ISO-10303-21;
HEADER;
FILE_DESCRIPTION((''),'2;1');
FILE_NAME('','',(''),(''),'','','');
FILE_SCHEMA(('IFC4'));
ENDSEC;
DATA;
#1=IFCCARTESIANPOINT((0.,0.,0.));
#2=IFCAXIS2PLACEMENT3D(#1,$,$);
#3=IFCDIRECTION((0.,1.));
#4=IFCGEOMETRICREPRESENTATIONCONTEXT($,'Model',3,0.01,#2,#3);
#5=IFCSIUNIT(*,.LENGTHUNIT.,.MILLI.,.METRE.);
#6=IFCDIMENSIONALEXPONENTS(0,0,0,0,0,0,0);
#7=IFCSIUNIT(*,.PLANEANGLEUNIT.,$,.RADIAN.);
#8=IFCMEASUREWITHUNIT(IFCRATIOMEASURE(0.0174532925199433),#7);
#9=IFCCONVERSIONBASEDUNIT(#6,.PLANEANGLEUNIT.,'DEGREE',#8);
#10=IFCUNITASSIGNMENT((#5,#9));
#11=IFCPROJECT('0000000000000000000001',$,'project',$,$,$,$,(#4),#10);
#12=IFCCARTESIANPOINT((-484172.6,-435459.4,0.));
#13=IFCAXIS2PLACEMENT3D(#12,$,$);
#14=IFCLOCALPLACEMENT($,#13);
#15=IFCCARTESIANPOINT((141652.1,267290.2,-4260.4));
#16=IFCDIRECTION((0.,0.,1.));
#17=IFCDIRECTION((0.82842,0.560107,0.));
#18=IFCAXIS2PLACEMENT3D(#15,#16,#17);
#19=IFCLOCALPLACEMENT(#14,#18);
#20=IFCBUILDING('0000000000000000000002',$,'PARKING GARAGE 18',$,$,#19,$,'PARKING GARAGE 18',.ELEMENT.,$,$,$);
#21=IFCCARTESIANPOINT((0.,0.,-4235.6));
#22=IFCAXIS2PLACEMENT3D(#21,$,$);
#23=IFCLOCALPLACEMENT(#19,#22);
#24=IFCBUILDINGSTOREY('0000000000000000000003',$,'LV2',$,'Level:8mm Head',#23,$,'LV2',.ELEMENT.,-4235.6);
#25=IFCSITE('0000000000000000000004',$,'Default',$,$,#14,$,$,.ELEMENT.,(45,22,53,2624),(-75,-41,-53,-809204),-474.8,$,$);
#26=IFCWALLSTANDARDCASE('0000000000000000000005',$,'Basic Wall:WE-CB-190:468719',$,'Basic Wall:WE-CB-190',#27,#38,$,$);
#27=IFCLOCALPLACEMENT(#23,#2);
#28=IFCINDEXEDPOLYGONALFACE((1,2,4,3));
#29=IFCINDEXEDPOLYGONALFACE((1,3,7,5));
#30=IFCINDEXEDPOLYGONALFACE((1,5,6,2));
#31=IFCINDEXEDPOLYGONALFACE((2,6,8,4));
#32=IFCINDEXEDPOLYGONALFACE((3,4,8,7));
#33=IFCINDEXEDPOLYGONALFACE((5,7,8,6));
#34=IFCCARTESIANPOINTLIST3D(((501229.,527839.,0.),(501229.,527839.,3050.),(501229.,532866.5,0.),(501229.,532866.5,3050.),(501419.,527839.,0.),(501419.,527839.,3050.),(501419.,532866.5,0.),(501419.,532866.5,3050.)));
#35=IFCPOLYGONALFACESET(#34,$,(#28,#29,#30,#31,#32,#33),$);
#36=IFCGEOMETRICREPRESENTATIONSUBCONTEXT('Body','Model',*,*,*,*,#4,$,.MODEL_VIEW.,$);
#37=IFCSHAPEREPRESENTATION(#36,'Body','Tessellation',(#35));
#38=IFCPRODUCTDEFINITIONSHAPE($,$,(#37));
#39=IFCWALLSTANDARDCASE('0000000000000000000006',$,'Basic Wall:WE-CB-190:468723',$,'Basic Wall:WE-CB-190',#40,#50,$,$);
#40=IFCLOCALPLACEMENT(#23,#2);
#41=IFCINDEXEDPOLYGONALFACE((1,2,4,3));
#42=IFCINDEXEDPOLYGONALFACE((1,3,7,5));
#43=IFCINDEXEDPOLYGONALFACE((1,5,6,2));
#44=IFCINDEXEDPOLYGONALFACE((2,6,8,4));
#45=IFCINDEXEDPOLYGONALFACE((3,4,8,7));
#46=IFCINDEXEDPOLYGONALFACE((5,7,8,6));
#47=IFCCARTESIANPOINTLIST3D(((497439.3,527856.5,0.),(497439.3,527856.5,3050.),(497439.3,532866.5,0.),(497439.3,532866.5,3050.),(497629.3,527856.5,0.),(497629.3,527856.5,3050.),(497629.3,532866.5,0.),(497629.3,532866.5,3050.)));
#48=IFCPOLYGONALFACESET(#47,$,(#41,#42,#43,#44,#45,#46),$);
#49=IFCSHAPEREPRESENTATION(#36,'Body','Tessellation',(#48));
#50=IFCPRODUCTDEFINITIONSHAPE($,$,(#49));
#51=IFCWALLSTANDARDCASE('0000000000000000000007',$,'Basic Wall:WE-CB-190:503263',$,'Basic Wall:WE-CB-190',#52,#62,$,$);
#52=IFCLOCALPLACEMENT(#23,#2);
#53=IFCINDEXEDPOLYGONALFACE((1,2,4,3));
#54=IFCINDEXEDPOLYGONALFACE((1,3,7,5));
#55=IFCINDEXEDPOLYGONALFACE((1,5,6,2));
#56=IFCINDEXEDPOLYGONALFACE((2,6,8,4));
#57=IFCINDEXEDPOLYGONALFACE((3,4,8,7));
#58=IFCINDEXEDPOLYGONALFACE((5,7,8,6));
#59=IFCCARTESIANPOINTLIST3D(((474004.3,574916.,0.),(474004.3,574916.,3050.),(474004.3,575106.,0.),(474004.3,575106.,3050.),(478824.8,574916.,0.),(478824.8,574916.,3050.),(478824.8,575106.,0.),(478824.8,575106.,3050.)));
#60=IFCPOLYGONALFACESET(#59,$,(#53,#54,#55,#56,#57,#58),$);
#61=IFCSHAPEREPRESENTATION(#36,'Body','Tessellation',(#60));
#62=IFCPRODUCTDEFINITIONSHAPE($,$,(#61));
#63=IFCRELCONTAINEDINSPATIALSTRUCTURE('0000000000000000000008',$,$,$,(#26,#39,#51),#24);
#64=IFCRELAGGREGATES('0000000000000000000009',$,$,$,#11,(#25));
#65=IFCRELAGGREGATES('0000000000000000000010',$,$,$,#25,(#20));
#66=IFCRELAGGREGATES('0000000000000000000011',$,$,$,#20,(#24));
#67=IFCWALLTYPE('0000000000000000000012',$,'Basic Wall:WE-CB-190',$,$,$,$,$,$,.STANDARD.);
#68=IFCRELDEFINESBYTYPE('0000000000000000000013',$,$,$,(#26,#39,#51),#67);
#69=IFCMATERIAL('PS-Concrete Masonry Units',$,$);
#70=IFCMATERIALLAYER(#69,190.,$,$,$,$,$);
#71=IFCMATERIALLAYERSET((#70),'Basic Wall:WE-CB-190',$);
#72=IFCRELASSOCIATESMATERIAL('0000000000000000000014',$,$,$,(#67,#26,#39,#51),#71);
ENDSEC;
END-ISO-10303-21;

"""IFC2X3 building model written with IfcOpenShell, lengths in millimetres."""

from ifc_helpers import new_model, entity, si_unit, converted_unit, direction, frame, frame_2d, origin, place, context, subcontext, project, spatial, rectangle, extrude, material, layer, layer_set, layer_usage, type_object, element, save


model = new_model("IFC2X3")

# Units and contexts
model_context = context("Model", 3, precision=0.01, world=origin(), true_north=direction((0.0, 1.0)))
body_context = subcontext(model_context, "Body", "Model", "MODEL_VIEW")
ifc_project = project(units=[si_unit("LENGTHUNIT", "METRE", prefix="MILLI"), converted_unit("PLANEANGLEUNIT", "DEGREE", entity("IfcRatioMeasure", 0.0174532925199433), si_unit("PLANEANGLEUNIT", "RADIAN"), dimensions=[0, 0, 0, 0, 0, 0, 0])], contexts=[model_context])

# Site, building, storey
site_placement = place(None, frame((-484172.6, -435459.4, 0.0)))
site = spatial("IfcSite", under=ifc_project, at=site_placement, Name="Default", CompositionType="ELEMENT", RefLatitude=(45, 22, 53, 2624), RefLongitude=(-75, -41, -53, -809204), RefElevation=-474.8)
building_placement = place(site_placement, frame((141652.1, 267290.2, -4260.4), z_axis=(0.0, 0.0, 1.0), x_axis=(0.82842, 0.560107, 0.0)))
building = spatial("IfcBuilding", under=site, at=building_placement, Name="PARKING GARAGE 18", LongName="PARKING GARAGE 18", CompositionType="ELEMENT")
storey_placement = place(building_placement, frame((0.0, 0.0, -4235.6)))
storey = spatial("IfcBuildingStorey", under=building, at=storey_placement, Name="LV2", ObjectType="Level:8mm Head", LongName="LV2", CompositionType="ELEMENT", Elevation=-4235.6)

# Shared definitions
ifc_material_1 = material(Name="PS-Concrete Masonry Units")
ifc_layer_1 = layer(ifc_material_1, 190.0)
ifc_layer_set_1 = layer_set([ifc_layer_1], Name="Basic Wall:WE-CB-190")
wall_type_1 = type_object("IfcWallType", Name="Basic Wall:WE-CB-190", PredefinedType="STANDARD", material=ifc_layer_set_1)

# Walls
ifc_layer_usage_1 = layer_usage(ifc_layer_set_1, "AXIS2", "NEGATIVE", 95.0)
wall_1_placement = place(storey_placement, frame((501324.0, 532866.5, 0.0), z_axis=(0.0, 0.0, 1.0), x_axis=(0.0, -1.0, 0.0)))
element("IfcWallStandardCase", 1, at=wall_1_placement, inside=storey, type_object=wall_type_1, material=ifc_layer_usage_1, Name="Basic Wall:WE-CB-190:468719", ObjectType="Basic Wall:WE-CB-190", context=body_context, shape_type="SweptSolid", body=[
    extrude(rectangle(XDim=5027.5, YDim=190.0, at=frame_2d((2513.8, 0.0), x_axis=(-1.0, 0.0))), origin(), (0.0, 0.0, 1.0), 3050.0),
])
ifc_layer_usage_2 = layer_usage(ifc_layer_set_1, "AXIS2", "NEGATIVE", 95.0)
wall_2_placement = place(storey_placement, frame((497534.3, 527856.5, 0.0), z_axis=(0.0, 0.0, 1.0), x_axis=(0.0, 1.0, 0.0)))
element("IfcWallStandardCase", 2, at=wall_2_placement, inside=storey, type_object=wall_type_1, material=ifc_layer_usage_2, Name="Basic Wall:WE-CB-190:468723", ObjectType="Basic Wall:WE-CB-190", context=body_context, shape_type="SweptSolid", body=[
    extrude(rectangle(XDim=5010.0, YDim=190.0, at=frame_2d((2505.0, 0.0), x_axis=(-1.0, 0.0))), origin(), (0.0, 0.0, 1.0), 3050.0),
])
ifc_layer_usage_3 = layer_usage(ifc_layer_set_1, "AXIS2", "NEGATIVE", 95.0)
wall_3_placement = place(storey_placement, frame((474004.3, 575011.0, 0.0)))
element("IfcWallStandardCase", 3, at=wall_3_placement, inside=storey, type_object=wall_type_1, material=ifc_layer_usage_3, Name="Basic Wall:WE-CB-190:503263", ObjectType="Basic Wall:WE-CB-190", context=body_context, shape_type="SweptSolid", body=[
    extrude(rectangle(XDim=4820.5, YDim=190.0, at=frame_2d((2410.2, 0.0), x_axis=(-1.0, 0.0))), origin(), (0.0, 0.0, 1.0), 3050.0),
])

save(model, "model.ifc")
